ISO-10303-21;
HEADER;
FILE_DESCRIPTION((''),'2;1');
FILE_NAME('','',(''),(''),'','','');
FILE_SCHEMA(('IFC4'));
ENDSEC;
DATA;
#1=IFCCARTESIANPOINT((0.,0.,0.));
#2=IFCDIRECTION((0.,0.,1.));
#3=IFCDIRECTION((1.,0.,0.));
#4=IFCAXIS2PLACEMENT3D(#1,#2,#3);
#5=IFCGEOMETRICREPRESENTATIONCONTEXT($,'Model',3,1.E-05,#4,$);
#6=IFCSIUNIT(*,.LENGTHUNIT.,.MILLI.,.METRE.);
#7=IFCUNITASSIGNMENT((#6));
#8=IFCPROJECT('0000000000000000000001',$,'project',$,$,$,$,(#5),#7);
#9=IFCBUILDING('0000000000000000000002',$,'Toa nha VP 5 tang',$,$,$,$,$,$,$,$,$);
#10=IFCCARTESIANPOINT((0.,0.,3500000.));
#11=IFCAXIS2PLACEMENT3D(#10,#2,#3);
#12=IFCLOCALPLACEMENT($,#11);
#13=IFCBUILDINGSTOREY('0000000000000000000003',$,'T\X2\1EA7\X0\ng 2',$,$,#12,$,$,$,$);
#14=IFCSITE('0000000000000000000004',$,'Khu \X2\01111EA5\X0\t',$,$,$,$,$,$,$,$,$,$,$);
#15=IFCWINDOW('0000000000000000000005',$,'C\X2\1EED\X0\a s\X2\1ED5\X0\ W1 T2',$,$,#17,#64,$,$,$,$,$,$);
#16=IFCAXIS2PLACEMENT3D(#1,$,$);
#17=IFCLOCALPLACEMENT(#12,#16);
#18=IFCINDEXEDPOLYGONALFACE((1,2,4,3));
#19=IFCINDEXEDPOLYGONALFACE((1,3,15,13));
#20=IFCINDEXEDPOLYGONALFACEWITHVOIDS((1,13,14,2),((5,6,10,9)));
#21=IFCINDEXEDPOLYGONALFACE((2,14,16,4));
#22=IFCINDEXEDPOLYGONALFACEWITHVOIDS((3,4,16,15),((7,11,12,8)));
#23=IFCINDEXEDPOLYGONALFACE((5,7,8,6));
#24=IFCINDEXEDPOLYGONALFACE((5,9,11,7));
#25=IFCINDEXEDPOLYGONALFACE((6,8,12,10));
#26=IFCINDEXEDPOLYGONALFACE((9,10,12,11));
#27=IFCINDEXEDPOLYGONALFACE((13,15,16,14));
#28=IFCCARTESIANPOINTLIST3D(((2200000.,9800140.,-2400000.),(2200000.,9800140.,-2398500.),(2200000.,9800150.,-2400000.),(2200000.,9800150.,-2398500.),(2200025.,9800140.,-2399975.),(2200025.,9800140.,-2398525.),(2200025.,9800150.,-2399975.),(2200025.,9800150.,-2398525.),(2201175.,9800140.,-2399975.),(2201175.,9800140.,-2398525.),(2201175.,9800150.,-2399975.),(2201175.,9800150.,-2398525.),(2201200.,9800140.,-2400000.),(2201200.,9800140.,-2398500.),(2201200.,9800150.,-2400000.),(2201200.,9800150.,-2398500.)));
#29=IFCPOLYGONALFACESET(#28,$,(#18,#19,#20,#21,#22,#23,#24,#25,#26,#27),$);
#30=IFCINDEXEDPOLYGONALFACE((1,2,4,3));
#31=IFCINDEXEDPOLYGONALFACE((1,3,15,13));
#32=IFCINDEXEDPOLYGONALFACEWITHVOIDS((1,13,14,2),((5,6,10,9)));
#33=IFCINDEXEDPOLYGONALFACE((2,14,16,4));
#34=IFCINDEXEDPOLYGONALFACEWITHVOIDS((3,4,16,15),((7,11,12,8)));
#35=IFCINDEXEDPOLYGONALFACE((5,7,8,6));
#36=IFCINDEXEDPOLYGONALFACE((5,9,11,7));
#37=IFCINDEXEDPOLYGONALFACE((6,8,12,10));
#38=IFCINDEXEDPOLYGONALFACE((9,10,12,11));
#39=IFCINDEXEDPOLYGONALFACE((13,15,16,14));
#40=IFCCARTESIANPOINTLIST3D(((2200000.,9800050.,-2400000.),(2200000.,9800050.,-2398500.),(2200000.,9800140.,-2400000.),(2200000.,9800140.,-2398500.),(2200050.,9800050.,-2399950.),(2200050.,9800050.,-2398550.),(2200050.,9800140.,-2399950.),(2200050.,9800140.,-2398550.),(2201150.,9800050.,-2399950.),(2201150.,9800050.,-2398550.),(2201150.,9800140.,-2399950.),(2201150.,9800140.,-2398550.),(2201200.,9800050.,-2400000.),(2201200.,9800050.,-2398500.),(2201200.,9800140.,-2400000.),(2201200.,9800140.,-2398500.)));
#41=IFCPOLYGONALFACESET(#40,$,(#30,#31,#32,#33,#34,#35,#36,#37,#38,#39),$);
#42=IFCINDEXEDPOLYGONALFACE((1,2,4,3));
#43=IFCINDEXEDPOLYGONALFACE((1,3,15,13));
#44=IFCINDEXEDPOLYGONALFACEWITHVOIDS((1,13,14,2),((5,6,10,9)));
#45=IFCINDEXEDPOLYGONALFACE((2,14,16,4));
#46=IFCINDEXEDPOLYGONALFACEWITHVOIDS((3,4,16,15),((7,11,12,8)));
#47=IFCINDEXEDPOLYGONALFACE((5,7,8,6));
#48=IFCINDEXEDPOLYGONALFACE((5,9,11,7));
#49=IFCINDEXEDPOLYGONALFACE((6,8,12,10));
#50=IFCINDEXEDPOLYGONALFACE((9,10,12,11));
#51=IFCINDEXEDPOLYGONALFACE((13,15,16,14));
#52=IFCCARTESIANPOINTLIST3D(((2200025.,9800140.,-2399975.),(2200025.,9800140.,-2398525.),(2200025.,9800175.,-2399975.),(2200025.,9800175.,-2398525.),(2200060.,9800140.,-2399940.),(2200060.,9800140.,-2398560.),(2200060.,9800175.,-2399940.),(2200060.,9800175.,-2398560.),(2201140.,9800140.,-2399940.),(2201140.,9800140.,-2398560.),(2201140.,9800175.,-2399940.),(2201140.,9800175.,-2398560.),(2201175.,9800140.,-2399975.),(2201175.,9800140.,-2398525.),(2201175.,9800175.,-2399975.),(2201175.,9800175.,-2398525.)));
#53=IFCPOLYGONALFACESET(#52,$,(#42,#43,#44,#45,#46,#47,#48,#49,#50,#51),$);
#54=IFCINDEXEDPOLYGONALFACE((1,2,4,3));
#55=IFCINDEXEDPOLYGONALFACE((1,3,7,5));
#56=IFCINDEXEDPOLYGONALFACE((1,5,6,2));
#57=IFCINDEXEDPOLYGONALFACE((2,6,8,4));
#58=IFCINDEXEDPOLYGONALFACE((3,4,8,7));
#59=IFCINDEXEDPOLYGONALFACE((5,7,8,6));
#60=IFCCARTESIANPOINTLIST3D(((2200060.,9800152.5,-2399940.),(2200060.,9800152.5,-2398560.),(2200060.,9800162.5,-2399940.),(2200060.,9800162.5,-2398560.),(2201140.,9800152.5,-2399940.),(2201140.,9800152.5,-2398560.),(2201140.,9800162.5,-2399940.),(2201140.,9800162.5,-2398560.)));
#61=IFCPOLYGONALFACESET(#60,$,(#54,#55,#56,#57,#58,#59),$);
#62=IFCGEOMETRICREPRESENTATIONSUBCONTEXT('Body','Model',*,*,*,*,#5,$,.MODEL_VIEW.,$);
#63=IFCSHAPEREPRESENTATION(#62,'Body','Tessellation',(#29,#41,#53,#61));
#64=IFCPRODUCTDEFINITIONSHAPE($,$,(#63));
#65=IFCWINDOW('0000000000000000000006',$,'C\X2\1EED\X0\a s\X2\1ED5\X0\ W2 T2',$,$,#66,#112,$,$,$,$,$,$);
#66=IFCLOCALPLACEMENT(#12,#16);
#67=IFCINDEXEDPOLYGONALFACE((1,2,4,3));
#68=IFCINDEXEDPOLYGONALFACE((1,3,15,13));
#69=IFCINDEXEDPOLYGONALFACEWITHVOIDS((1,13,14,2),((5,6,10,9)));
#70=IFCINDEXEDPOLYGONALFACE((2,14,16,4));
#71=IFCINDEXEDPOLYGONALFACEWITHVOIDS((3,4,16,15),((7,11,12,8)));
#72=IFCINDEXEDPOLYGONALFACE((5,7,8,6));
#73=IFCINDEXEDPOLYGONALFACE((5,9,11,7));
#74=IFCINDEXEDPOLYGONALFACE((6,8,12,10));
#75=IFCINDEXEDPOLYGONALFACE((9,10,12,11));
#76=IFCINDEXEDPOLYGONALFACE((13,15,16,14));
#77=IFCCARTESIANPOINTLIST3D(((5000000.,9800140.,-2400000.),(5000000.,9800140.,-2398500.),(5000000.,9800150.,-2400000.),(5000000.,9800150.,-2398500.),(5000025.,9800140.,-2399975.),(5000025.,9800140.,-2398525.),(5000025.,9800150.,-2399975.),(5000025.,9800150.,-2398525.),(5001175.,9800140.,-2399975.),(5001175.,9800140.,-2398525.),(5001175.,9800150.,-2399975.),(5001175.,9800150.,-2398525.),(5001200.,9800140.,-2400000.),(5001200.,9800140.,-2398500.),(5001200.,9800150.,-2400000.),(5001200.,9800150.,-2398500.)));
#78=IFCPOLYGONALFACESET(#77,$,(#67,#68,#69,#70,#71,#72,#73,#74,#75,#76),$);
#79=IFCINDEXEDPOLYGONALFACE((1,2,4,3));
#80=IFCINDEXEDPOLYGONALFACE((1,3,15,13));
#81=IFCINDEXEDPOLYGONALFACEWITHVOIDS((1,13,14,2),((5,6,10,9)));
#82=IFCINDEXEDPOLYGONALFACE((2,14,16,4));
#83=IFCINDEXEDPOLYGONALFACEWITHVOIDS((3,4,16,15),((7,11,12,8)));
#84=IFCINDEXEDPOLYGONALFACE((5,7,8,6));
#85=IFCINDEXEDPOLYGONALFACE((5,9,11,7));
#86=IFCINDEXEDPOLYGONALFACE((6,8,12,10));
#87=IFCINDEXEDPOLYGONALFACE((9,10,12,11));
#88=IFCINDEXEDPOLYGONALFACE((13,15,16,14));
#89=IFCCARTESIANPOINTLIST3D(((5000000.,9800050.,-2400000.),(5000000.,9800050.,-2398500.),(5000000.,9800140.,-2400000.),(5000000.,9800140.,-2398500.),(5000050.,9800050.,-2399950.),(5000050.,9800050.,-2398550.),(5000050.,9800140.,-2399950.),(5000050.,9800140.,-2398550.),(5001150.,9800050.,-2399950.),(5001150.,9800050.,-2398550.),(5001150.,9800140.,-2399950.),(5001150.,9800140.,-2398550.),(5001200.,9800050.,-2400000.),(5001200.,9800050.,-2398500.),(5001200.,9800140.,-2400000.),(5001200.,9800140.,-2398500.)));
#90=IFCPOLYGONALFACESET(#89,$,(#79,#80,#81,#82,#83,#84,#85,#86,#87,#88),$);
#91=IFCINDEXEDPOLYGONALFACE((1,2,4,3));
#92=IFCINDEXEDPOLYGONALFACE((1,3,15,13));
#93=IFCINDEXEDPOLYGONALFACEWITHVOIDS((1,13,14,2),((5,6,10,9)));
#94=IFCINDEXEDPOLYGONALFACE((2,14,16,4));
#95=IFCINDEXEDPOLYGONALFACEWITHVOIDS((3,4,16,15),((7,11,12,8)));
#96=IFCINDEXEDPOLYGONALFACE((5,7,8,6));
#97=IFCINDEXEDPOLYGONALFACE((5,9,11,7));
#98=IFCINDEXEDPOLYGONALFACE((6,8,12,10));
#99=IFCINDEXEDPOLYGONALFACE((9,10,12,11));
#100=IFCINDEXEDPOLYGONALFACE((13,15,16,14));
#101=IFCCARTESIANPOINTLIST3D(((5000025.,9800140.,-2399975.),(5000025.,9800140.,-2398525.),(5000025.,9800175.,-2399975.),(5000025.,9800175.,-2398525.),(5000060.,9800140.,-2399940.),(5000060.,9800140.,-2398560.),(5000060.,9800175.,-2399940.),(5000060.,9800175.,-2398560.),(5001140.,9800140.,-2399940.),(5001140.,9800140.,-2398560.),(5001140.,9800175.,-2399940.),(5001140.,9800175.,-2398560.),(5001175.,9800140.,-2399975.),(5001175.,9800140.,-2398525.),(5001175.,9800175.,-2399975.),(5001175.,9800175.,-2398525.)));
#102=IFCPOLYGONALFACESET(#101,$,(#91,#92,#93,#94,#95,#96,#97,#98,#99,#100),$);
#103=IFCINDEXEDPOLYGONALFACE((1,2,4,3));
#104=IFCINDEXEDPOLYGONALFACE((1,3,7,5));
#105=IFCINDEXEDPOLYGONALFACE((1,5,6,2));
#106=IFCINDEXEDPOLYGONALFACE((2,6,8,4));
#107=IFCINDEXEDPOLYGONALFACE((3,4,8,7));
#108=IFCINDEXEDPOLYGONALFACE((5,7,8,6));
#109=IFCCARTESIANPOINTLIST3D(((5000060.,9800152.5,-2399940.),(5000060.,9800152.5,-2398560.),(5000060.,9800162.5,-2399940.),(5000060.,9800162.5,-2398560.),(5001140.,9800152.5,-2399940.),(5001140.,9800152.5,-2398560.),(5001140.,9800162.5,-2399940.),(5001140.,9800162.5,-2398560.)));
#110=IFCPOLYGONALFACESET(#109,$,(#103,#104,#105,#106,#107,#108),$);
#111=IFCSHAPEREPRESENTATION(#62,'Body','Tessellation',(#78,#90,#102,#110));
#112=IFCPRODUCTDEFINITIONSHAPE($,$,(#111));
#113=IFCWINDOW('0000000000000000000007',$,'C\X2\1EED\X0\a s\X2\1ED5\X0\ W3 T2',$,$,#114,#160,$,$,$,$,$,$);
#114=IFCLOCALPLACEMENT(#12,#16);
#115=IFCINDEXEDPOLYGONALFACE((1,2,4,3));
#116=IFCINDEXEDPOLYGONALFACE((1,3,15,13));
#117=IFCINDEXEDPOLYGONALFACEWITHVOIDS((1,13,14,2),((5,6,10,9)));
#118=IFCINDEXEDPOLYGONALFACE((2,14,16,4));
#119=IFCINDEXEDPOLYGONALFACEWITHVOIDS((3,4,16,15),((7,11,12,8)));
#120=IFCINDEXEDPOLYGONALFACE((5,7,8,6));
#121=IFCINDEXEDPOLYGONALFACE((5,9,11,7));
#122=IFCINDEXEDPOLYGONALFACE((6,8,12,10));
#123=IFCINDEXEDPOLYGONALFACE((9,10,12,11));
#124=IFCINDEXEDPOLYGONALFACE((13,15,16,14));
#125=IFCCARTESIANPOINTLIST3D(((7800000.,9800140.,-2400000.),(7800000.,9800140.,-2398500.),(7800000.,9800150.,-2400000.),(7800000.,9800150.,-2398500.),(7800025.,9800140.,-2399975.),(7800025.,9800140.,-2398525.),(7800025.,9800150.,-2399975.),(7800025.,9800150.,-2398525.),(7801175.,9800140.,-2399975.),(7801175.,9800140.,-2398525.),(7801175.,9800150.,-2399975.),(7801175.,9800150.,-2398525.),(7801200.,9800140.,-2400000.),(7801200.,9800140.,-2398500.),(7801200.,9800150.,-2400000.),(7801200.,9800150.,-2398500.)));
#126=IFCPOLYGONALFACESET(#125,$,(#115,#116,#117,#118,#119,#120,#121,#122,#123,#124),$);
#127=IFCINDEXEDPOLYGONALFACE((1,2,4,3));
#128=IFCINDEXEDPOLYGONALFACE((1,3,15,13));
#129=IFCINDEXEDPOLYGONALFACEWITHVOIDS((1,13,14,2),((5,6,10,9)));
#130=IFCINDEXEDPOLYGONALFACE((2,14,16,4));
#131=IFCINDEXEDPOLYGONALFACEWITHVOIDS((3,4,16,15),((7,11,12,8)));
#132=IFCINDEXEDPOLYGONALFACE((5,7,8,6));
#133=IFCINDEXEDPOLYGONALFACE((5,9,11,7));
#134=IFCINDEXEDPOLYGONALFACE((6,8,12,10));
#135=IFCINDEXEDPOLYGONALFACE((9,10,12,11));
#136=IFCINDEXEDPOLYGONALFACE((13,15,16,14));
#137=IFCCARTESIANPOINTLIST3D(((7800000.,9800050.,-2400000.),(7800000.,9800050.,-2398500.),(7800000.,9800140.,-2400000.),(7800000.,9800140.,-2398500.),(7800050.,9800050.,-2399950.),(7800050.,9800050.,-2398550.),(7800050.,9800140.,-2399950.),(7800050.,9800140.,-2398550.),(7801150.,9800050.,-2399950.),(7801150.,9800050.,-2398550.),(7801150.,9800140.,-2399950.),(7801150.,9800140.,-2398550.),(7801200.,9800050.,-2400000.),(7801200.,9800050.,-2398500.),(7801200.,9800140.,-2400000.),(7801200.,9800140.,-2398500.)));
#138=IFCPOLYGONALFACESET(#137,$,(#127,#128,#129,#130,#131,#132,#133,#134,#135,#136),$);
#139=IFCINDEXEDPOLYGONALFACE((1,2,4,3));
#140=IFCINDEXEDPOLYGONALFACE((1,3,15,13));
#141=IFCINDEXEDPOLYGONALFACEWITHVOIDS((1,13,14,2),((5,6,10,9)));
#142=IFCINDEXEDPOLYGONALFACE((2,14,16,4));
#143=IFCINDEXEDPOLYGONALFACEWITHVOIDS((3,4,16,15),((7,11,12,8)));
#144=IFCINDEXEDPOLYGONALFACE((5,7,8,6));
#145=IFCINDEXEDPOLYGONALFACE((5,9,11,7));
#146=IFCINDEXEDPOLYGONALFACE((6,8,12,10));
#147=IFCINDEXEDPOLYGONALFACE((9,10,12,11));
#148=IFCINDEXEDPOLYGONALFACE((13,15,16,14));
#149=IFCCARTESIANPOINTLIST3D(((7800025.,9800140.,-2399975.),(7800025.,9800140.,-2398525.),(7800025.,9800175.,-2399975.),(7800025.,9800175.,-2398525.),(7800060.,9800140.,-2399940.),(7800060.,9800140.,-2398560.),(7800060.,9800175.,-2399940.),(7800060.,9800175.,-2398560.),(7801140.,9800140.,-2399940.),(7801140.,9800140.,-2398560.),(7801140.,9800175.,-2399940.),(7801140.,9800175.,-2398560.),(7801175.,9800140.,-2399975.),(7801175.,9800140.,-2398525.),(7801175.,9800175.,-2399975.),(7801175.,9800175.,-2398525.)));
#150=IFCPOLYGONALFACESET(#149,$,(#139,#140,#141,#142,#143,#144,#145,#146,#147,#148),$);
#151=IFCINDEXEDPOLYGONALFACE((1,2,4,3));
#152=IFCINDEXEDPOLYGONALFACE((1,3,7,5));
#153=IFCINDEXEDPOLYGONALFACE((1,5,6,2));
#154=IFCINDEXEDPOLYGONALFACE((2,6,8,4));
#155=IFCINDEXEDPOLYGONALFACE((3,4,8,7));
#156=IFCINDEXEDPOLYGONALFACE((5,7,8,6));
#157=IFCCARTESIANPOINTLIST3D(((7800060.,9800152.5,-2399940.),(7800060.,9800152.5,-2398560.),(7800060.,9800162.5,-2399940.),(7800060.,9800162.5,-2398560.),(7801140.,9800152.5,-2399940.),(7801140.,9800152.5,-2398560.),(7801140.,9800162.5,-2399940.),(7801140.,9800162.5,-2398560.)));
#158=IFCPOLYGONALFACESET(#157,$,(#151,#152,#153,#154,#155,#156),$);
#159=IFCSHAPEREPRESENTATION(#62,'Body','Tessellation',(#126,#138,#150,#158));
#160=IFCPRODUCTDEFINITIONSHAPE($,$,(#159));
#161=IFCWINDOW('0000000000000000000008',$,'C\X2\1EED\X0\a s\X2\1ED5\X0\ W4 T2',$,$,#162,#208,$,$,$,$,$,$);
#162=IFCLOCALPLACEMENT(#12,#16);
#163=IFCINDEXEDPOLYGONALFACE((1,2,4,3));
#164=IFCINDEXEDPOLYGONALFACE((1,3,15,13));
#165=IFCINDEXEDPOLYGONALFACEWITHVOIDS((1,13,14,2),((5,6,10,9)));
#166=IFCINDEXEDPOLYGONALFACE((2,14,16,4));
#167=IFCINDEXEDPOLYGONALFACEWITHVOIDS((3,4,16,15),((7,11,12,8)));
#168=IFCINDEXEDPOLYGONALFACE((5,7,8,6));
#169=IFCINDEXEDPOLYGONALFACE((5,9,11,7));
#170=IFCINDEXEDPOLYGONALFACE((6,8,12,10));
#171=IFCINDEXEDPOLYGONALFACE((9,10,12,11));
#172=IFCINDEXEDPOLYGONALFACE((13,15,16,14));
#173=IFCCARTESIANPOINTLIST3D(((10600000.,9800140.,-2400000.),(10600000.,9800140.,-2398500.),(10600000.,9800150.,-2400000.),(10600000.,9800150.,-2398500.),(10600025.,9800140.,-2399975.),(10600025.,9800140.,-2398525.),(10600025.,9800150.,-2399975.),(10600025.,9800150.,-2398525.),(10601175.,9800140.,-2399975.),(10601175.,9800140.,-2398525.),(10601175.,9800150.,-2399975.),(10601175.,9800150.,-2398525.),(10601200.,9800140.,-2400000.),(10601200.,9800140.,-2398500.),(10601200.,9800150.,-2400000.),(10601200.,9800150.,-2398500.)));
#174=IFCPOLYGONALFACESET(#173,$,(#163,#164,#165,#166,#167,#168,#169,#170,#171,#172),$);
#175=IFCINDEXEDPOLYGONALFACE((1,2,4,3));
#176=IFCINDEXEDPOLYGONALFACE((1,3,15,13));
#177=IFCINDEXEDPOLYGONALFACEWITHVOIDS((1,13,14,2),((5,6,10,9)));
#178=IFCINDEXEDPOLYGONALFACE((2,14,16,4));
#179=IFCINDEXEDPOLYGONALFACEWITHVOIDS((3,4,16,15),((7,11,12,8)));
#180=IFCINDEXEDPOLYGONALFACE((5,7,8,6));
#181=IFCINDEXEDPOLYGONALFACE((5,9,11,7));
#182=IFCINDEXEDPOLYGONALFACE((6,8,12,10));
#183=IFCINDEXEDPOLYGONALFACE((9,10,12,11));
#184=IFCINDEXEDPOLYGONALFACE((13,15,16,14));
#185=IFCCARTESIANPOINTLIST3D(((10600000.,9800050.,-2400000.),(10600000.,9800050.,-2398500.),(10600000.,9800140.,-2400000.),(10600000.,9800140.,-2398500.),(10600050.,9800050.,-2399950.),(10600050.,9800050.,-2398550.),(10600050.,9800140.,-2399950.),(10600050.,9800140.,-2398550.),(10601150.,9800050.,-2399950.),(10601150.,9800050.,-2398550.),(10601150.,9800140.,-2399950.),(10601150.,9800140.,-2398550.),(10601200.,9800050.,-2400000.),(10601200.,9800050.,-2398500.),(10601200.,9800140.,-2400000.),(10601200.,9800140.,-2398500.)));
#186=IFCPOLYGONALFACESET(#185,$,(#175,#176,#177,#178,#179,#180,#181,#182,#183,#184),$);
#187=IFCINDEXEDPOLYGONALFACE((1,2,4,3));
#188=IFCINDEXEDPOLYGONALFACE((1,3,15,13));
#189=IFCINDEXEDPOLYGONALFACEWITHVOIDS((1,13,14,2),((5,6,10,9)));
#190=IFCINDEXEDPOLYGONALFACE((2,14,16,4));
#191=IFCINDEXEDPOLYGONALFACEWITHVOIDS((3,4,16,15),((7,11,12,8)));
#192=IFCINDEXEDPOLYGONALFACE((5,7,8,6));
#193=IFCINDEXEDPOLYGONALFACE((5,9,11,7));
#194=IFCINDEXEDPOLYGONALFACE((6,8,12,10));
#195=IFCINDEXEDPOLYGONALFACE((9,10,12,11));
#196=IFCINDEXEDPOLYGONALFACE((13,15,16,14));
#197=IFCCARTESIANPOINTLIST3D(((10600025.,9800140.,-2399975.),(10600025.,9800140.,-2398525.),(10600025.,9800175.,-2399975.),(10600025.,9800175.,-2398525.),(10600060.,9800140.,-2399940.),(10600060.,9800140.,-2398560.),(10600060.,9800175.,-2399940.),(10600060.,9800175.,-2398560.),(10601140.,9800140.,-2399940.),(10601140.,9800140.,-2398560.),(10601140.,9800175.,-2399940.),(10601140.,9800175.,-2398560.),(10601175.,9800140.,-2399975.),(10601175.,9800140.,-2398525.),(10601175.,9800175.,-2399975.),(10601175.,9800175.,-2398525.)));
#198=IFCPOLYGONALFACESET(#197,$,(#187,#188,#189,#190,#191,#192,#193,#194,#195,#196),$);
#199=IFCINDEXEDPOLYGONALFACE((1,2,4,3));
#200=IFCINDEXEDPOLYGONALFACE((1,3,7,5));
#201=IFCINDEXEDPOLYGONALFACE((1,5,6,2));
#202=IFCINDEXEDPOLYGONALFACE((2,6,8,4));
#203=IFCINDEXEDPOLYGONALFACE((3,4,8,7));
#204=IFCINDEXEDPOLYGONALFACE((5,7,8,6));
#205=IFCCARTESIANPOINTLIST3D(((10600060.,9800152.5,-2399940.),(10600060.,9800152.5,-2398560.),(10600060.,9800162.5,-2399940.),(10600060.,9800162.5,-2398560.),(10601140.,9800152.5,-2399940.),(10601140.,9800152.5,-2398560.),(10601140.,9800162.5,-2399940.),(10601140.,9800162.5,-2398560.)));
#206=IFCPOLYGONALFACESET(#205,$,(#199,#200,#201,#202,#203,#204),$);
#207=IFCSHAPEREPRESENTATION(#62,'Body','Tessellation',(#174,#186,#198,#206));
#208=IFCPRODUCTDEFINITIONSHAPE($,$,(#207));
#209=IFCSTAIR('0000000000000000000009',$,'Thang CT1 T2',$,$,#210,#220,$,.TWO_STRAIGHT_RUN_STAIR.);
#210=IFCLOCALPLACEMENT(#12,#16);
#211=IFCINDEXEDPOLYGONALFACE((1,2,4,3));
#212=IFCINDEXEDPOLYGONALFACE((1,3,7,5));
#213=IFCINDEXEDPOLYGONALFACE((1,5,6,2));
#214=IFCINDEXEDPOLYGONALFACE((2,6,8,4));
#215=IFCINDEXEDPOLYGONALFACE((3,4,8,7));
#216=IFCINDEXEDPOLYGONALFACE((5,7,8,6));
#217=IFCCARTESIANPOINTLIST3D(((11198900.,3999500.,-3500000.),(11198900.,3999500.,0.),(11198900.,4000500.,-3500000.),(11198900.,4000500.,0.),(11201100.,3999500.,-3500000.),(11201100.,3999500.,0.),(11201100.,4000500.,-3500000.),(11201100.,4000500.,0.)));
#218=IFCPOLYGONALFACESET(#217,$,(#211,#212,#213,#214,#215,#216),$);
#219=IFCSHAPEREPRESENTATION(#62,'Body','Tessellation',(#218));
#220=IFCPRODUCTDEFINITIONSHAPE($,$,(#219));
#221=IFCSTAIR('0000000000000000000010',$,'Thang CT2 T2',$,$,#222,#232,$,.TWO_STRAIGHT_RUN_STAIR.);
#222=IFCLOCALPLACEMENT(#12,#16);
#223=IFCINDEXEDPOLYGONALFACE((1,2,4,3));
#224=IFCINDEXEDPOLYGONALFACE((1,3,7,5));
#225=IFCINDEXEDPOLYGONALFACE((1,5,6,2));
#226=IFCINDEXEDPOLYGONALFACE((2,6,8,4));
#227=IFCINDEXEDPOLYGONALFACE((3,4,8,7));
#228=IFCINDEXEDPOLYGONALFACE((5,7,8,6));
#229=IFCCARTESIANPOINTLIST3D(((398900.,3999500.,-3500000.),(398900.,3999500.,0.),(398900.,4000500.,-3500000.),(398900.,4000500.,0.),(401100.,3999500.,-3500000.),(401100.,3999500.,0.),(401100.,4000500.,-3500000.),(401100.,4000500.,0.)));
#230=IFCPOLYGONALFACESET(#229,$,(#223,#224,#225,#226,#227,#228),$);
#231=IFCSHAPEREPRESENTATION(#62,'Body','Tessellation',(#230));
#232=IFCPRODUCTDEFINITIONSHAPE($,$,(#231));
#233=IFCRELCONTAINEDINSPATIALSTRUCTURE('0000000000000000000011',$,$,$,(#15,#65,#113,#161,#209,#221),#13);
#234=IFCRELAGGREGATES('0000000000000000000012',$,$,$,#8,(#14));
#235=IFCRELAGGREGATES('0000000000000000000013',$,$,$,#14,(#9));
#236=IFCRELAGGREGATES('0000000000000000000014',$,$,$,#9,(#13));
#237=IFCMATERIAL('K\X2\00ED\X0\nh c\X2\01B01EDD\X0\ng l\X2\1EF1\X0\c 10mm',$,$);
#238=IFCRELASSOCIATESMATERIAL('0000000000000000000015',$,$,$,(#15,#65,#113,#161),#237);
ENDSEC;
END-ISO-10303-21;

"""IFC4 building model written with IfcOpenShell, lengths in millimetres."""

from ifc_helpers import new_model, entity, si_unit, frame, origin_with_axes, place, context, subcontext, project, spatial, line, indexed_curve, outline, extrude, material, element, save


model = new_model("IFC4")

# Units and contexts
model_context = context("Model", 3, precision=1e-05, world=origin_with_axes())
body_context = subcontext(model_context, "Body", "Model", "MODEL_VIEW")
ifc_project = project(units=[si_unit("LENGTHUNIT", "METRE", prefix="MILLI")], contexts=[model_context])

# Site, building, storey
site = spatial("IfcSite", under=ifc_project, Name="Khu đất")
building = spatial("IfcBuilding", under=site, Name="Toa nha VP 5 tang")
storey_placement = place(None, frame((0.0, 0.0, 3500000.0), z_axis=(0.0, 0.0, 1.0), x_axis=(1.0, 0.0, 0.0)))
storey = spatial("IfcBuildingStorey", under=building, at=storey_placement, Name="Tầng 2")

# Windows
ifc_material_1 = material(Name="Kính cường lực 10mm")
for number, where, z_axis, x_axis, name in (
    (1, (2200000.0, 9800000.0, -2400000.0), (0.0, 0.0, 1.0), (1.0, 0.0, 0.0), "Cửa sổ W1 T2"),
    (2, (5000000.0, 9800000.0, -2400000.0), (0.0, 0.0, 1.0), (1.0, 0.0, 0.0), "Cửa sổ W2 T2"),
    (3, (7800000.0, 9800000.0, -2400000.0), (0.0, 0.0, 1.0), (1.0, 0.0, 0.0), "Cửa sổ W3 T2"),
    (4, (10600000.0, 9800000.0, -2400000.0), (0.0, 0.0, 1.0), (1.0, 0.0, 0.0), "Cửa sổ W4 T2"),
):
    element("IfcWindow", number, at=place(storey_placement, frame(where, z_axis=z_axis, x_axis=x_axis)), inside=storey, material=ifc_material_1, Name=name, context=body_context, shape_type="SolidModel", body=[
        extrude(outline(indexed_curve([(0.0, 0.0), (1200.0, 0.0), (1200.0, 1500.0), (0.0, 1500.0)], segments=[line(1, 2, 3, 4, 1)]), holes=[indexed_curve([(25.0, 25.0), (1175.0, 25.0), (1175.0, 1475.0), (25.0, 1475.0)], segments=[line(1, 2, 3, 4, 1)])]), frame((0.0, 140.0, 0.0), z_axis=(0.0, -1.0, 0.0), x_axis=(1.0, 0.0, 0.0)), (0.0, 0.0, -1.0), 10.0),
        extrude(outline(indexed_curve([(0.0, 0.0), (1200.0, 0.0), (1200.0, 1500.0), (0.0, 1500.0)], segments=[line(1, 2, 3, 4, 1)]), holes=[indexed_curve([(50.0, 50.0), (1150.0, 50.0), (1150.0, 1450.0), (50.0, 1450.0)], segments=[line(1, 2, 3, 4, 1)])]), frame((0.0, 50.0, 0.0), z_axis=(0.0, -1.0, 0.0), x_axis=(1.0, 0.0, 0.0)), (0.0, 0.0, -1.0), 90.0),
        extrude(outline(indexed_curve([(0.0, 0.0), (1150.0, 0.0), (1150.0, 1450.0), (0.0, 1450.0)], segments=[line(1, 2, 3, 4, 1)]), holes=[indexed_curve([(35.0, 35.0), (1115.0, 35.0), (1115.0, 1415.0), (35.0, 1415.0)], segments=[line(1, 2, 3, 4, 1)])]), frame((25.0, 140.0, 25.0), z_axis=(0.0, -1.0, 0.0), x_axis=(1.0, 0.0, 0.0)), (0.0, 0.0, -1.0), 35.0),
        extrude(outline(indexed_curve([(35.0, 35.0), (1115.0, 35.0), (1115.0, 1415.0), (35.0, 1415.0)], segments=[line(1, 2, 3, 4, 1)])), frame((25.0, 152.5, 25.0), z_axis=(0.0, -1.0, 0.0), x_axis=(1.0, 0.0, 0.0)), (0.0, 0.0, -1.0), 10.0),
    ])

# Stairs
for number, where, z_axis, x_axis, name in (
    (5, (11200000.0, 4000000.0, -3500000.0), (0.0, 0.0, 1.0), (1.0, 0.0, 0.0), "Thang CT1 T2"),
    (6, (400000.0, 4000000.0, -3500000.0), (0.0, 0.0, 1.0), (1.0, 0.0, 0.0), "Thang CT2 T2"),
):
    element("IfcStair", number, at=place(storey_placement, frame(where, z_axis=z_axis, x_axis=x_axis)), inside=storey, Name=name, PredefinedType="TWO_STRAIGHT_RUN_STAIR", context=body_context, shape_type="SweptSolid", body=[
        extrude(entity("IfcRectangleProfileDef", None, None, None, 2200.0, 1000.0), origin_with_axes(), (0.0, 0.0, 1.0), 3500000.0),
    ])

save(model, "model.ifc")
